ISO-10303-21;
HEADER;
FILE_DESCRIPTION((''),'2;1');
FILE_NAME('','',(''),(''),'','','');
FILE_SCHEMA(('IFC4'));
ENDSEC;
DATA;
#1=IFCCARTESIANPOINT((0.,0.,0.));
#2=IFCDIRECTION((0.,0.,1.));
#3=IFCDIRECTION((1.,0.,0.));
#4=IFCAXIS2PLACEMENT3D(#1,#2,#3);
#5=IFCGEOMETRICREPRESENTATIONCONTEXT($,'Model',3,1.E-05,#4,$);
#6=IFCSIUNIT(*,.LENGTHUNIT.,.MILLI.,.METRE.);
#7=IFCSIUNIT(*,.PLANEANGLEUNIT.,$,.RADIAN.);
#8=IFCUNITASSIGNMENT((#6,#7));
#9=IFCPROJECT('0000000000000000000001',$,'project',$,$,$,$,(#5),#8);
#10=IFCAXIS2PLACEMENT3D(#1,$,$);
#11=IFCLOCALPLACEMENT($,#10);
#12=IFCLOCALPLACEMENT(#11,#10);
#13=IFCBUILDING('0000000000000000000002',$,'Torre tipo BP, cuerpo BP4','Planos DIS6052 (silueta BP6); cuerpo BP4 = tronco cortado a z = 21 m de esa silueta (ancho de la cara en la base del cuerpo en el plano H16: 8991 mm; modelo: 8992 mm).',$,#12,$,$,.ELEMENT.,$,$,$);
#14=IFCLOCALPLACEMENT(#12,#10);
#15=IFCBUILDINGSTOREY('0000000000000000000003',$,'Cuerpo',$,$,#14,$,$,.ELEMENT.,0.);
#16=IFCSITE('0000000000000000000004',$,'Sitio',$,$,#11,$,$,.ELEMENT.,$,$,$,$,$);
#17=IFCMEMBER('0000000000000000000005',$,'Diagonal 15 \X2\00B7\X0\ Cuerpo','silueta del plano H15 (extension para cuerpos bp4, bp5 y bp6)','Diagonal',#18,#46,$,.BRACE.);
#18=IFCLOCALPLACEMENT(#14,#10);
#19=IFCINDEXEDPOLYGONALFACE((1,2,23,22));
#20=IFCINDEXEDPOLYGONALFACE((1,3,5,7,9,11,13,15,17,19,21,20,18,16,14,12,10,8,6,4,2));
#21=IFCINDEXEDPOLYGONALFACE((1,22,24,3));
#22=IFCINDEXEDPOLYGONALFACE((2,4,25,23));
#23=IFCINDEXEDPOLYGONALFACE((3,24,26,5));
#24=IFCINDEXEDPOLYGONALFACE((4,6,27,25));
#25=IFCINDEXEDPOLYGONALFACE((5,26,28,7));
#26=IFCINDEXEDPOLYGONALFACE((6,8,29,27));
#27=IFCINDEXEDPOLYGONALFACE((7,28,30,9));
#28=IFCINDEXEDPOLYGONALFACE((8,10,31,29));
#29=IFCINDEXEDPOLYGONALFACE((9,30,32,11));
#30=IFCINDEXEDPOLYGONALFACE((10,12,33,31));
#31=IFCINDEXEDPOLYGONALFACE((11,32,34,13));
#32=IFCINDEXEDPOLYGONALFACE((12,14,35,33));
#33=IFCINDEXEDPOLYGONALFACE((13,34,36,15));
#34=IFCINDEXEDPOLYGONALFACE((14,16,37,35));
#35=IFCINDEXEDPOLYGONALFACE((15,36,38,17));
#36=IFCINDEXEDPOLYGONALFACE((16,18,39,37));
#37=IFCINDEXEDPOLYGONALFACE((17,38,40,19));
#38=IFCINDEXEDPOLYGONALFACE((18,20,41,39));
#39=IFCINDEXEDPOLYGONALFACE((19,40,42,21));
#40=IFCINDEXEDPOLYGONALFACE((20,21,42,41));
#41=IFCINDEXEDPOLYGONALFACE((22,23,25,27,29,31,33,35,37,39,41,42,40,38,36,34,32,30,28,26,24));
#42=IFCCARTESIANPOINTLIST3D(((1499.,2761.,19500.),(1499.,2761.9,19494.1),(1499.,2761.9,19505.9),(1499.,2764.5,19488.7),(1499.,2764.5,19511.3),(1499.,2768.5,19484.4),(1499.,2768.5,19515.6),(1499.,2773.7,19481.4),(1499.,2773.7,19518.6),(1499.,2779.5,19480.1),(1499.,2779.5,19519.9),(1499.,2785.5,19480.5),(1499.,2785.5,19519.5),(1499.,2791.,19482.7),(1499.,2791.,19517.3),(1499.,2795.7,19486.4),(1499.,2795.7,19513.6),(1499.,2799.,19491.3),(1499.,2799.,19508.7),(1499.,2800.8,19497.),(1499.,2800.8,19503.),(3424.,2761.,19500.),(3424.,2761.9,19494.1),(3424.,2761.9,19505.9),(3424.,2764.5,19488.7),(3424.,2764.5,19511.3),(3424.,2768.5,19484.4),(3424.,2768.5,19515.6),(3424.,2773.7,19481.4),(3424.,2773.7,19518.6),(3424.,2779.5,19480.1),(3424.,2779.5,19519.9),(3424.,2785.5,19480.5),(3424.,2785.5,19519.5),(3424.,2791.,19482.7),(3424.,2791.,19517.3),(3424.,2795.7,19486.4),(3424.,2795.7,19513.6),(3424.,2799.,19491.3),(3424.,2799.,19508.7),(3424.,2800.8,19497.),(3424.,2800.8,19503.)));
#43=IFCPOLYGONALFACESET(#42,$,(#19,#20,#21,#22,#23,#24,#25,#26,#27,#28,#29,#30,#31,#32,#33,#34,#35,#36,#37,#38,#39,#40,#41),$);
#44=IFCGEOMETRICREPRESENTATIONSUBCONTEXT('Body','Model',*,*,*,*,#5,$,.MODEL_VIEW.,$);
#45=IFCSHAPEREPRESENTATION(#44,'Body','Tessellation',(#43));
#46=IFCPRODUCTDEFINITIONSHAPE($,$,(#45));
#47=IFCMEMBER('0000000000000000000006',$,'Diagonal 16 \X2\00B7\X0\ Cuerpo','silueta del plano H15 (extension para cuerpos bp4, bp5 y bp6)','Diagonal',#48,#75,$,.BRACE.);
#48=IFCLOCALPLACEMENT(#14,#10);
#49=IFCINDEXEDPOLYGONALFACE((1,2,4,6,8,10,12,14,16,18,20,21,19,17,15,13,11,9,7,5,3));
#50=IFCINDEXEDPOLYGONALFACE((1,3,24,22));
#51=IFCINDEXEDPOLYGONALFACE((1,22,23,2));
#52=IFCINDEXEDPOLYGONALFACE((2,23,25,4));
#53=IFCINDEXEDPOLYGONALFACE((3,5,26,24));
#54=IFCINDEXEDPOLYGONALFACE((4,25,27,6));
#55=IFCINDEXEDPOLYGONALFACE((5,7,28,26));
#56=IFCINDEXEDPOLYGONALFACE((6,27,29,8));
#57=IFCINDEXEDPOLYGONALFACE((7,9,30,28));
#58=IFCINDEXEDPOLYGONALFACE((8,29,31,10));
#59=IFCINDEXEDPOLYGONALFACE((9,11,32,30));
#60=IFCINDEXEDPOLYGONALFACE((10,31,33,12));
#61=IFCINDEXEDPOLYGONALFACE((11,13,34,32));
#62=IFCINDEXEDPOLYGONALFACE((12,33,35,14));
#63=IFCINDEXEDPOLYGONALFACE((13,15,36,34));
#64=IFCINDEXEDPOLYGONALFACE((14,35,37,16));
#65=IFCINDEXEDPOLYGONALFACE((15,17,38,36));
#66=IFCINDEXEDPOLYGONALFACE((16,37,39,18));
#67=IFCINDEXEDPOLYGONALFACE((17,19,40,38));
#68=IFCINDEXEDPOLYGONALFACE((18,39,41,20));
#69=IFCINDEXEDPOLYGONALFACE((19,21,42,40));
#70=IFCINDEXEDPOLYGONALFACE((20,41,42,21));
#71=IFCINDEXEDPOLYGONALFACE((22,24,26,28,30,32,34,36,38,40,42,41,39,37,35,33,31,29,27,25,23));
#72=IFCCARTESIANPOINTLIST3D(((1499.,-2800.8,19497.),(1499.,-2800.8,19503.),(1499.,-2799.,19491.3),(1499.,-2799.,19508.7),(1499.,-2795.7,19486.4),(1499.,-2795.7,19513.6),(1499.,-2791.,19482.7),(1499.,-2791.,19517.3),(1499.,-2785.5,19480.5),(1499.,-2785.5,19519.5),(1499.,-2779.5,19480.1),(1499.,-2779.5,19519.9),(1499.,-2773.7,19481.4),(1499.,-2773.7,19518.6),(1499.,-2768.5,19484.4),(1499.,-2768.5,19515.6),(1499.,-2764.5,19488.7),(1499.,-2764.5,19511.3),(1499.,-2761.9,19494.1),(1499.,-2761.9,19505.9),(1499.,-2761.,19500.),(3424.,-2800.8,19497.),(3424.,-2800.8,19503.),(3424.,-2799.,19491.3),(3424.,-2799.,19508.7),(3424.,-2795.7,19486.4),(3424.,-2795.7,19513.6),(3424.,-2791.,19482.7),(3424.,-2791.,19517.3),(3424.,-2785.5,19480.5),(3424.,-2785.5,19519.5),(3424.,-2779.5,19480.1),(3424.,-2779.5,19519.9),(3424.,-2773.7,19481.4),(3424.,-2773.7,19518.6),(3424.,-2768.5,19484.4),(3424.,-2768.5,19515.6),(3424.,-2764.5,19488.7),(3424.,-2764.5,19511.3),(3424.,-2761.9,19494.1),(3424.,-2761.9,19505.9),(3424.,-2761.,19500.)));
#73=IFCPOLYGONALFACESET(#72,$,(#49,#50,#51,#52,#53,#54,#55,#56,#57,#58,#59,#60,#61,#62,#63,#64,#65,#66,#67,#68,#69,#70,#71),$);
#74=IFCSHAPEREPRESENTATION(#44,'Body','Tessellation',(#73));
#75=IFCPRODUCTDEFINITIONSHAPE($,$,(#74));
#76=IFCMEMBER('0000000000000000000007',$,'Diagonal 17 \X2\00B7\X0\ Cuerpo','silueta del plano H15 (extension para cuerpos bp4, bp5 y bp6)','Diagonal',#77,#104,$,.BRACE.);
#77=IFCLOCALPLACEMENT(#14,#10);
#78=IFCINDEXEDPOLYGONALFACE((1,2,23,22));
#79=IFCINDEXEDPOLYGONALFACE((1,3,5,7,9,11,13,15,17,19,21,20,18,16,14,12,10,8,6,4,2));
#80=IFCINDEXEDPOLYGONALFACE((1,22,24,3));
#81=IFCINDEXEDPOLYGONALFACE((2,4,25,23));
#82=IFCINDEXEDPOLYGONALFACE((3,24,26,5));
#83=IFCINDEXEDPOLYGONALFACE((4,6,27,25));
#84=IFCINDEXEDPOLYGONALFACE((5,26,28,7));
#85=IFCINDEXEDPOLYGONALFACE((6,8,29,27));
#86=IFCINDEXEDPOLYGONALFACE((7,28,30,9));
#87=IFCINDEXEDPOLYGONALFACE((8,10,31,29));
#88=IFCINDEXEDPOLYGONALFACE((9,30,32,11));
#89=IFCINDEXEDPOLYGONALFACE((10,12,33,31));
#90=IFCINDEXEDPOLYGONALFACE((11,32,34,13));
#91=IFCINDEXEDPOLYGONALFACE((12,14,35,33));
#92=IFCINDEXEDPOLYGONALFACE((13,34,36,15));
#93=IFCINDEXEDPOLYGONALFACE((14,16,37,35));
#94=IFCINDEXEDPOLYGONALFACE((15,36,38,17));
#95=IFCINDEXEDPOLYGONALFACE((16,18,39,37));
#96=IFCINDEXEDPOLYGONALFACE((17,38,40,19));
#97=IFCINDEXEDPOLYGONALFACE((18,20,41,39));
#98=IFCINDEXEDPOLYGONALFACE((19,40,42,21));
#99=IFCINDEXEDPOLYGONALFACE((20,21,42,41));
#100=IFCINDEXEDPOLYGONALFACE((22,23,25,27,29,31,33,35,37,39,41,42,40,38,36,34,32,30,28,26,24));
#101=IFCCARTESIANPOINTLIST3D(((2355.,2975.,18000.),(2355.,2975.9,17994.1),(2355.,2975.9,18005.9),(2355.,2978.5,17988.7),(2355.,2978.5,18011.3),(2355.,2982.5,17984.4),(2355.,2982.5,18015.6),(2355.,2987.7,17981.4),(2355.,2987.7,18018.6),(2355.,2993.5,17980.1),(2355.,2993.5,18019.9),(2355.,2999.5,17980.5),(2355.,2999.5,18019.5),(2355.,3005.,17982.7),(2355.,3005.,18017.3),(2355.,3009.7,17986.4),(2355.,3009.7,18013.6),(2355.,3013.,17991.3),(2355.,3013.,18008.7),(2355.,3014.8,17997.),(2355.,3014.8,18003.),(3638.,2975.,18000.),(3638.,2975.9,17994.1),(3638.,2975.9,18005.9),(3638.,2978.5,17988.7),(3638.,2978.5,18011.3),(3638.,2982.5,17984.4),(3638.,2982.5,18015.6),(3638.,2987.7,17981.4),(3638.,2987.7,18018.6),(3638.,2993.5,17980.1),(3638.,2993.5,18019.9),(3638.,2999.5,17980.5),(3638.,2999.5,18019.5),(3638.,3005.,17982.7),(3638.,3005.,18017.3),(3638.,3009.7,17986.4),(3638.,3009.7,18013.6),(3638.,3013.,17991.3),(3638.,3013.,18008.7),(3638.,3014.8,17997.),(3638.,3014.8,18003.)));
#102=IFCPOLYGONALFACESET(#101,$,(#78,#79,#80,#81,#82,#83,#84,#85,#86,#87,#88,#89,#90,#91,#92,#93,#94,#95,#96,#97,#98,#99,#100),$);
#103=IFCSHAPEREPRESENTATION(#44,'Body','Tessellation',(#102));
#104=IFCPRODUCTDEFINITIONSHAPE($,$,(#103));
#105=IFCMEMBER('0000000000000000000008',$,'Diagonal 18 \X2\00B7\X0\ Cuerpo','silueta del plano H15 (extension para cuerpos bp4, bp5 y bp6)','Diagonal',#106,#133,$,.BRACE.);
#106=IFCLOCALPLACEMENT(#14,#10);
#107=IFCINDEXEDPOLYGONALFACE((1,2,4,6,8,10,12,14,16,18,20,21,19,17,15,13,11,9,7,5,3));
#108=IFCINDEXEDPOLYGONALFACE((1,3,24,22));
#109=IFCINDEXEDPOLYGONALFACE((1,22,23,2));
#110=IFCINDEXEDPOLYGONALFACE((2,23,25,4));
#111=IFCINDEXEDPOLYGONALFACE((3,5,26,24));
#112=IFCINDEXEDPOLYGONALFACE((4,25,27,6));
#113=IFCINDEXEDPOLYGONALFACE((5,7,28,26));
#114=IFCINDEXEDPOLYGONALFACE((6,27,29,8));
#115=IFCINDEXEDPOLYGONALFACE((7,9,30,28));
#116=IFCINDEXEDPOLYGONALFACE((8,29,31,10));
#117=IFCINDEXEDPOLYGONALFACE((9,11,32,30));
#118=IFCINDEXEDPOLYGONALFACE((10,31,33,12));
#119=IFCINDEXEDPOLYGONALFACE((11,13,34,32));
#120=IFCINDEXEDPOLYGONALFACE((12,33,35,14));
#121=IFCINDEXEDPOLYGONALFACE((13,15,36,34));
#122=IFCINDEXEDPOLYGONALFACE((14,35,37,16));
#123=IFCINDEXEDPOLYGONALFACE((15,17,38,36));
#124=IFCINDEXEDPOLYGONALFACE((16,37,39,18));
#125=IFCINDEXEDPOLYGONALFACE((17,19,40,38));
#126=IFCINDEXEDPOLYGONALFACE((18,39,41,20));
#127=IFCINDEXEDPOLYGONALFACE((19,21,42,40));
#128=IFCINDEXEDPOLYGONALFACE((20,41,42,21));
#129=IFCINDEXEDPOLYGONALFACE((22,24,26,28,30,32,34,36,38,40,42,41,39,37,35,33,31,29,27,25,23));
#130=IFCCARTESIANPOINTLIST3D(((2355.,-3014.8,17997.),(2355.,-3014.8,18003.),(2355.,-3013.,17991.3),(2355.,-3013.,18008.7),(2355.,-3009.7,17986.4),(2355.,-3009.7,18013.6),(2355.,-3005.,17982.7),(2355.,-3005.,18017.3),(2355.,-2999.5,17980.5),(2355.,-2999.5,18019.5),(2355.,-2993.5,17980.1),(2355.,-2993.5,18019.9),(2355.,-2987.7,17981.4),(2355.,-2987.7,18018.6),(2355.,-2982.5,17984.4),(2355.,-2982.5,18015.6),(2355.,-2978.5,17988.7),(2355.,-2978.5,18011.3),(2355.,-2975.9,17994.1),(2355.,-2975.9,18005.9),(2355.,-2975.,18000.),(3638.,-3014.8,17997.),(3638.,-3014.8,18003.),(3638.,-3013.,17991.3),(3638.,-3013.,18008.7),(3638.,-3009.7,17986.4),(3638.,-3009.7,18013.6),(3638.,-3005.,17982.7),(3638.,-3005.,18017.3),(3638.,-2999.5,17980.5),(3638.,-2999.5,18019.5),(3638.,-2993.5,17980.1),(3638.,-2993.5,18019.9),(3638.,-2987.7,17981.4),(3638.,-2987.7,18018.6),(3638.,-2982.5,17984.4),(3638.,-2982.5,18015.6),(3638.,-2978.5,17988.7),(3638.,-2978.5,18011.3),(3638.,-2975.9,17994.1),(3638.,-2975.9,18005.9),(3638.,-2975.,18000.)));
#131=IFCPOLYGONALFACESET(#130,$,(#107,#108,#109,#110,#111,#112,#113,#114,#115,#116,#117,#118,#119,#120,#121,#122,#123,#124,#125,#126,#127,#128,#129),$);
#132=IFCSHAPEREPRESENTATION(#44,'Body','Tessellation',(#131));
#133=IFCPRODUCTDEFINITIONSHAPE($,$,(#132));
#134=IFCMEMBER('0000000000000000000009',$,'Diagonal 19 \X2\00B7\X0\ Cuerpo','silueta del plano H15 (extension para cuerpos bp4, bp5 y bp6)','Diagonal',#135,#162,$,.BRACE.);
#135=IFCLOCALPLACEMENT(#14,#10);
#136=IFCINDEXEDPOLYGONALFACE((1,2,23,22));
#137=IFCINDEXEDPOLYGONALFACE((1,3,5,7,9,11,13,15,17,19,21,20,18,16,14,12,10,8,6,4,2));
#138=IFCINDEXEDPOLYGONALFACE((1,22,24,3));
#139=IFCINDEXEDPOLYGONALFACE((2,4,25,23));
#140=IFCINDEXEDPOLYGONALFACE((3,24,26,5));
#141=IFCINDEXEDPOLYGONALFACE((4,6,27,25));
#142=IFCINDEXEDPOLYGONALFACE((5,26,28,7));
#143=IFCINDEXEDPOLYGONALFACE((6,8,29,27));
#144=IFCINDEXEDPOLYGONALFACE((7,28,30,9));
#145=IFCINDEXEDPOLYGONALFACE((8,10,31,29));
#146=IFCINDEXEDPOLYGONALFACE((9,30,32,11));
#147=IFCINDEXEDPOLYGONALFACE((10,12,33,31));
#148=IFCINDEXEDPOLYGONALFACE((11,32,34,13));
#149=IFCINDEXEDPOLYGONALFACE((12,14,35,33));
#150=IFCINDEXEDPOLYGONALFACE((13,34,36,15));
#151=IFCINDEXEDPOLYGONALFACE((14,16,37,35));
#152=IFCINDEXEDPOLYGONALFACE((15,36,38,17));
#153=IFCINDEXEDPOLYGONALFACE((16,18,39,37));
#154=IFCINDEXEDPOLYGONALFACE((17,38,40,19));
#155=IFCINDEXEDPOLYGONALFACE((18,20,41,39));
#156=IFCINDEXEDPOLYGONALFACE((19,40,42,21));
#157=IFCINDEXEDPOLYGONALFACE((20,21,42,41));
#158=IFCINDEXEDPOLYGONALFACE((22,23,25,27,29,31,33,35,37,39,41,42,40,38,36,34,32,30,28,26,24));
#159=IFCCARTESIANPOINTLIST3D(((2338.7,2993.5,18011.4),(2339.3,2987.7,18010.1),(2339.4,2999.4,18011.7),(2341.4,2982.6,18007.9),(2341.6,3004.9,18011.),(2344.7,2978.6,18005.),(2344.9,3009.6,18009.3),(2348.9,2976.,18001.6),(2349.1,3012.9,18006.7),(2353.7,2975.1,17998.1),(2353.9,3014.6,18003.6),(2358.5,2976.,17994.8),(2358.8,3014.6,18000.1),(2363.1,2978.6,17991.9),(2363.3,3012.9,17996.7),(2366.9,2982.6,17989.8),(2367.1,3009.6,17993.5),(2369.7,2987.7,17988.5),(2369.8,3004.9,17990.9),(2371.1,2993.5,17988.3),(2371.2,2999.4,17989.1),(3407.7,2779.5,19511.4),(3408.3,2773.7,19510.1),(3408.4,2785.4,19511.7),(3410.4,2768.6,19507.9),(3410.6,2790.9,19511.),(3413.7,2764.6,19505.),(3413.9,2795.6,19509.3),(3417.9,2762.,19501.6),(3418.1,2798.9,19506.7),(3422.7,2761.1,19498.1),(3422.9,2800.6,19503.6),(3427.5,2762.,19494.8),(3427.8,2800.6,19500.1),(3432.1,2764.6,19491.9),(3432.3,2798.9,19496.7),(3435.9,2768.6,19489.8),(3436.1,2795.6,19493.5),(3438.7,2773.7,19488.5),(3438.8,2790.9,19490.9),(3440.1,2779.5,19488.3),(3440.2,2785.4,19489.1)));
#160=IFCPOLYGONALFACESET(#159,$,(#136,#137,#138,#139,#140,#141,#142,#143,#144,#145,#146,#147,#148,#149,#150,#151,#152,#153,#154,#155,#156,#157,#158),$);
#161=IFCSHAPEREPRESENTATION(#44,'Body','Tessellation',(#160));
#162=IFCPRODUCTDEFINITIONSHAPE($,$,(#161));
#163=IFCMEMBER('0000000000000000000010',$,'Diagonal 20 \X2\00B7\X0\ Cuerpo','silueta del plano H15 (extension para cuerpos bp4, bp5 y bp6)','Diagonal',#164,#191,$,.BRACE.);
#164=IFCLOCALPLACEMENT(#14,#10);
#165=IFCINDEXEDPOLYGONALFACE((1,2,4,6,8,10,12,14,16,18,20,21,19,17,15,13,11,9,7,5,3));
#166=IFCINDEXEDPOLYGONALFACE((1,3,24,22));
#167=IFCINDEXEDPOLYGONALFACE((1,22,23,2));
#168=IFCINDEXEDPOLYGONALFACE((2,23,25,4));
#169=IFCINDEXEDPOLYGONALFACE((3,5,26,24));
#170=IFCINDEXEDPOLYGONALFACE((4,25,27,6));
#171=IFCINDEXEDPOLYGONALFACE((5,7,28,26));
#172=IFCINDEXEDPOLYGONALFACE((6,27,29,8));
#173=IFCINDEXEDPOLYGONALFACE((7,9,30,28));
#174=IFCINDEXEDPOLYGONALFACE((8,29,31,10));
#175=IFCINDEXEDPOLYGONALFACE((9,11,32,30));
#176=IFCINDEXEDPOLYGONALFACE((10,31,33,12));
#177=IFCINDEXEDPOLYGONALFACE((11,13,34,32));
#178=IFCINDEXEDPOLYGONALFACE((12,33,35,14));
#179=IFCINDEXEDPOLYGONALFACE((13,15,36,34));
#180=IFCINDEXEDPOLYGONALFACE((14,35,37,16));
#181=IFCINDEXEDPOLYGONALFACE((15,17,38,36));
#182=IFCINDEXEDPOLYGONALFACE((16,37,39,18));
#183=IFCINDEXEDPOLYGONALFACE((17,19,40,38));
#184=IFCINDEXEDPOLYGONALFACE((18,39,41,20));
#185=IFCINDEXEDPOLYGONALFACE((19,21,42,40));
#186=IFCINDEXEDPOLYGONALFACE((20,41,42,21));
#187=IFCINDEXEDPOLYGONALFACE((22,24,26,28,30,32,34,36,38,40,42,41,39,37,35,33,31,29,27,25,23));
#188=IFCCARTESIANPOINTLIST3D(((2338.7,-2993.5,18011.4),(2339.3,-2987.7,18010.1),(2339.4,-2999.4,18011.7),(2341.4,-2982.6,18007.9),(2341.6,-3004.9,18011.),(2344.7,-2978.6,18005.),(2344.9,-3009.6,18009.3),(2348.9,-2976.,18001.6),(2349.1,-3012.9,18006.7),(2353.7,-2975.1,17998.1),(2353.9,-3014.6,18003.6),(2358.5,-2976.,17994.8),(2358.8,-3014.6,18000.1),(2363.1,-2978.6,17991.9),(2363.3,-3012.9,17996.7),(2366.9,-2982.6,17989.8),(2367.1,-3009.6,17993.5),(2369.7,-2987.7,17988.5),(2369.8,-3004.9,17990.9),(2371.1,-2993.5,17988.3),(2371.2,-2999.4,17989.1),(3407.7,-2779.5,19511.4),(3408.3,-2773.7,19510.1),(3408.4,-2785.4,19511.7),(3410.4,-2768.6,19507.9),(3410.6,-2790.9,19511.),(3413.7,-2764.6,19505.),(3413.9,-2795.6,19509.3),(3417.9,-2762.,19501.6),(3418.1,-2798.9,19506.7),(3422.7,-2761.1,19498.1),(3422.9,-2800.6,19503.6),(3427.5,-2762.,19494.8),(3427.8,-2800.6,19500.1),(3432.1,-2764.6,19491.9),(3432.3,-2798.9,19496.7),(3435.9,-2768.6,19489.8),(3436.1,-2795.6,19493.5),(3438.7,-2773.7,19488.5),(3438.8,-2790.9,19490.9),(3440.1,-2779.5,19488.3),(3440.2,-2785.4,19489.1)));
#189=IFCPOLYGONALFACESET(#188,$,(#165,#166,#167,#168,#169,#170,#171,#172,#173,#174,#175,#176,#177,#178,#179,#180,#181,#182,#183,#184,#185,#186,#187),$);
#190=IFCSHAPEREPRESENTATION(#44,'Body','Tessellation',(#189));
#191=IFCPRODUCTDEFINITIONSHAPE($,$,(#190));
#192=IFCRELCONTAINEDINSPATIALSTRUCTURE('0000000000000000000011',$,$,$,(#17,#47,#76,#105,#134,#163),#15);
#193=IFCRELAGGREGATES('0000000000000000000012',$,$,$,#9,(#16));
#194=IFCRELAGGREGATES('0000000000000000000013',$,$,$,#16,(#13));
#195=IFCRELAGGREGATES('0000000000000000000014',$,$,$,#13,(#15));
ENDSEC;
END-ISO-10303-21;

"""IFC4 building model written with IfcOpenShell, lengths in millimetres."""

from ifc_helpers import new_model, si_unit, frame, origin, origin_with_axes, place, context, subcontext, project, spatial, circle, extrude, element, save


model = new_model("IFC4")

# Units and contexts
model_context = context("Model", 3, precision=1e-05, world=origin_with_axes())
body_context = subcontext(model_context, "Body", "Model", "MODEL_VIEW")
ifc_project = project(units=[si_unit("LENGTHUNIT", "METRE", prefix="MILLI"), si_unit("PLANEANGLEUNIT", "RADIAN")], contexts=[model_context])

# Site, building, storey
site_placement = place(None, origin())
site = spatial("IfcSite", under=ifc_project, at=site_placement, Name="Sitio", CompositionType="ELEMENT")
building_placement = place(site_placement, origin())
building = spatial("IfcBuilding", under=site, at=building_placement, Name="Torre tipo BP, cuerpo BP4", Description="Planos DIS6052 (silueta BP6); cuerpo BP4 = tronco cortado a z = 21 m de esa silueta (ancho de la cara en la base del cuerpo en el plano H16: 8991 mm; modelo: 8992 mm).", CompositionType="ELEMENT")
storey_placement = place(building_placement, origin())
storey = spatial("IfcBuildingStorey", under=building, at=storey_placement, Name="Cuerpo", CompositionType="ELEMENT", Elevation=0.0)

# Members
for number, where, z_axis, x_axis, name in (
    (1, (1499.0, 2781.0, 19500.0), (1.0, 0.0, 0.0), (0.0, -1.0, 0.0), "Diagonal 15 · Cuerpo"),
    (2, (1499.0, -2781.0, 19500.0), (1.0, 0.0, 0.0), (0.0, 1.0, 0.0), "Diagonal 16 · Cuerpo"),
):
    element("IfcMember", number, at=place(storey_placement, frame(where, z_axis=z_axis, x_axis=x_axis)), inside=storey, Name=name, Description="silueta del plano H15 (extension para cuerpos bp4, bp5 y bp6)", ObjectType="Diagonal", PredefinedType="BRACE", context=body_context, shape_type="SweptSolid", body=[
        extrude(circle(Radius=20.0), None, (0.0, 0.0, 1.0), 1925.0),
    ])
for number, where, z_axis, x_axis, name in (
    (3, (2355.0, 2995.0, 18000.0), (1.0, 0.0, 0.0), (0.0, -1.0, 0.0), "Diagonal 17 · Cuerpo"),
    (4, (2355.0, -2995.0, 18000.0), (1.0, 0.0, 0.0), (0.0, 1.0, 0.0), "Diagonal 18 · Cuerpo"),
):
    element("IfcMember", number, at=place(storey_placement, frame(where, z_axis=z_axis, x_axis=x_axis)), inside=storey, Name=name, Description="silueta del plano H15 (extension para cuerpos bp4, bp5 y bp6)", ObjectType="Diagonal", PredefinedType="BRACE", context=body_context, shape_type="SweptSolid", body=[
        extrude(circle(Radius=20.0), None, (0.0, 0.0, 1.0), 1283.0),
    ])
for number, where, z_axis, x_axis, name in (
    (5, (2355.0, 2995.0, 18000.0), (0.576487, -0.115405, 0.808915), (-0.066977, -0.993318, -0.093981), "Diagonal 19 · Cuerpo"),
    (6, (2355.0, -2995.0, 18000.0), (0.576487, 0.115405, 0.808915), (-0.066977, 0.993318, -0.093981), "Diagonal 20 · Cuerpo"),
):
    element("IfcMember", number, at=place(storey_placement, frame(where, z_axis=z_axis, x_axis=x_axis)), inside=storey, Name=name, Description="silueta del plano H15 (extension para cuerpos bp4, bp5 y bp6)", ObjectType="Diagonal", PredefinedType="BRACE", context=body_context, shape_type="SweptSolid", body=[
        extrude(circle(Radius=20.0), None, (0.0, 0.0, 1.0), 1854.3),
    ])

save(model, "model.ifc")
